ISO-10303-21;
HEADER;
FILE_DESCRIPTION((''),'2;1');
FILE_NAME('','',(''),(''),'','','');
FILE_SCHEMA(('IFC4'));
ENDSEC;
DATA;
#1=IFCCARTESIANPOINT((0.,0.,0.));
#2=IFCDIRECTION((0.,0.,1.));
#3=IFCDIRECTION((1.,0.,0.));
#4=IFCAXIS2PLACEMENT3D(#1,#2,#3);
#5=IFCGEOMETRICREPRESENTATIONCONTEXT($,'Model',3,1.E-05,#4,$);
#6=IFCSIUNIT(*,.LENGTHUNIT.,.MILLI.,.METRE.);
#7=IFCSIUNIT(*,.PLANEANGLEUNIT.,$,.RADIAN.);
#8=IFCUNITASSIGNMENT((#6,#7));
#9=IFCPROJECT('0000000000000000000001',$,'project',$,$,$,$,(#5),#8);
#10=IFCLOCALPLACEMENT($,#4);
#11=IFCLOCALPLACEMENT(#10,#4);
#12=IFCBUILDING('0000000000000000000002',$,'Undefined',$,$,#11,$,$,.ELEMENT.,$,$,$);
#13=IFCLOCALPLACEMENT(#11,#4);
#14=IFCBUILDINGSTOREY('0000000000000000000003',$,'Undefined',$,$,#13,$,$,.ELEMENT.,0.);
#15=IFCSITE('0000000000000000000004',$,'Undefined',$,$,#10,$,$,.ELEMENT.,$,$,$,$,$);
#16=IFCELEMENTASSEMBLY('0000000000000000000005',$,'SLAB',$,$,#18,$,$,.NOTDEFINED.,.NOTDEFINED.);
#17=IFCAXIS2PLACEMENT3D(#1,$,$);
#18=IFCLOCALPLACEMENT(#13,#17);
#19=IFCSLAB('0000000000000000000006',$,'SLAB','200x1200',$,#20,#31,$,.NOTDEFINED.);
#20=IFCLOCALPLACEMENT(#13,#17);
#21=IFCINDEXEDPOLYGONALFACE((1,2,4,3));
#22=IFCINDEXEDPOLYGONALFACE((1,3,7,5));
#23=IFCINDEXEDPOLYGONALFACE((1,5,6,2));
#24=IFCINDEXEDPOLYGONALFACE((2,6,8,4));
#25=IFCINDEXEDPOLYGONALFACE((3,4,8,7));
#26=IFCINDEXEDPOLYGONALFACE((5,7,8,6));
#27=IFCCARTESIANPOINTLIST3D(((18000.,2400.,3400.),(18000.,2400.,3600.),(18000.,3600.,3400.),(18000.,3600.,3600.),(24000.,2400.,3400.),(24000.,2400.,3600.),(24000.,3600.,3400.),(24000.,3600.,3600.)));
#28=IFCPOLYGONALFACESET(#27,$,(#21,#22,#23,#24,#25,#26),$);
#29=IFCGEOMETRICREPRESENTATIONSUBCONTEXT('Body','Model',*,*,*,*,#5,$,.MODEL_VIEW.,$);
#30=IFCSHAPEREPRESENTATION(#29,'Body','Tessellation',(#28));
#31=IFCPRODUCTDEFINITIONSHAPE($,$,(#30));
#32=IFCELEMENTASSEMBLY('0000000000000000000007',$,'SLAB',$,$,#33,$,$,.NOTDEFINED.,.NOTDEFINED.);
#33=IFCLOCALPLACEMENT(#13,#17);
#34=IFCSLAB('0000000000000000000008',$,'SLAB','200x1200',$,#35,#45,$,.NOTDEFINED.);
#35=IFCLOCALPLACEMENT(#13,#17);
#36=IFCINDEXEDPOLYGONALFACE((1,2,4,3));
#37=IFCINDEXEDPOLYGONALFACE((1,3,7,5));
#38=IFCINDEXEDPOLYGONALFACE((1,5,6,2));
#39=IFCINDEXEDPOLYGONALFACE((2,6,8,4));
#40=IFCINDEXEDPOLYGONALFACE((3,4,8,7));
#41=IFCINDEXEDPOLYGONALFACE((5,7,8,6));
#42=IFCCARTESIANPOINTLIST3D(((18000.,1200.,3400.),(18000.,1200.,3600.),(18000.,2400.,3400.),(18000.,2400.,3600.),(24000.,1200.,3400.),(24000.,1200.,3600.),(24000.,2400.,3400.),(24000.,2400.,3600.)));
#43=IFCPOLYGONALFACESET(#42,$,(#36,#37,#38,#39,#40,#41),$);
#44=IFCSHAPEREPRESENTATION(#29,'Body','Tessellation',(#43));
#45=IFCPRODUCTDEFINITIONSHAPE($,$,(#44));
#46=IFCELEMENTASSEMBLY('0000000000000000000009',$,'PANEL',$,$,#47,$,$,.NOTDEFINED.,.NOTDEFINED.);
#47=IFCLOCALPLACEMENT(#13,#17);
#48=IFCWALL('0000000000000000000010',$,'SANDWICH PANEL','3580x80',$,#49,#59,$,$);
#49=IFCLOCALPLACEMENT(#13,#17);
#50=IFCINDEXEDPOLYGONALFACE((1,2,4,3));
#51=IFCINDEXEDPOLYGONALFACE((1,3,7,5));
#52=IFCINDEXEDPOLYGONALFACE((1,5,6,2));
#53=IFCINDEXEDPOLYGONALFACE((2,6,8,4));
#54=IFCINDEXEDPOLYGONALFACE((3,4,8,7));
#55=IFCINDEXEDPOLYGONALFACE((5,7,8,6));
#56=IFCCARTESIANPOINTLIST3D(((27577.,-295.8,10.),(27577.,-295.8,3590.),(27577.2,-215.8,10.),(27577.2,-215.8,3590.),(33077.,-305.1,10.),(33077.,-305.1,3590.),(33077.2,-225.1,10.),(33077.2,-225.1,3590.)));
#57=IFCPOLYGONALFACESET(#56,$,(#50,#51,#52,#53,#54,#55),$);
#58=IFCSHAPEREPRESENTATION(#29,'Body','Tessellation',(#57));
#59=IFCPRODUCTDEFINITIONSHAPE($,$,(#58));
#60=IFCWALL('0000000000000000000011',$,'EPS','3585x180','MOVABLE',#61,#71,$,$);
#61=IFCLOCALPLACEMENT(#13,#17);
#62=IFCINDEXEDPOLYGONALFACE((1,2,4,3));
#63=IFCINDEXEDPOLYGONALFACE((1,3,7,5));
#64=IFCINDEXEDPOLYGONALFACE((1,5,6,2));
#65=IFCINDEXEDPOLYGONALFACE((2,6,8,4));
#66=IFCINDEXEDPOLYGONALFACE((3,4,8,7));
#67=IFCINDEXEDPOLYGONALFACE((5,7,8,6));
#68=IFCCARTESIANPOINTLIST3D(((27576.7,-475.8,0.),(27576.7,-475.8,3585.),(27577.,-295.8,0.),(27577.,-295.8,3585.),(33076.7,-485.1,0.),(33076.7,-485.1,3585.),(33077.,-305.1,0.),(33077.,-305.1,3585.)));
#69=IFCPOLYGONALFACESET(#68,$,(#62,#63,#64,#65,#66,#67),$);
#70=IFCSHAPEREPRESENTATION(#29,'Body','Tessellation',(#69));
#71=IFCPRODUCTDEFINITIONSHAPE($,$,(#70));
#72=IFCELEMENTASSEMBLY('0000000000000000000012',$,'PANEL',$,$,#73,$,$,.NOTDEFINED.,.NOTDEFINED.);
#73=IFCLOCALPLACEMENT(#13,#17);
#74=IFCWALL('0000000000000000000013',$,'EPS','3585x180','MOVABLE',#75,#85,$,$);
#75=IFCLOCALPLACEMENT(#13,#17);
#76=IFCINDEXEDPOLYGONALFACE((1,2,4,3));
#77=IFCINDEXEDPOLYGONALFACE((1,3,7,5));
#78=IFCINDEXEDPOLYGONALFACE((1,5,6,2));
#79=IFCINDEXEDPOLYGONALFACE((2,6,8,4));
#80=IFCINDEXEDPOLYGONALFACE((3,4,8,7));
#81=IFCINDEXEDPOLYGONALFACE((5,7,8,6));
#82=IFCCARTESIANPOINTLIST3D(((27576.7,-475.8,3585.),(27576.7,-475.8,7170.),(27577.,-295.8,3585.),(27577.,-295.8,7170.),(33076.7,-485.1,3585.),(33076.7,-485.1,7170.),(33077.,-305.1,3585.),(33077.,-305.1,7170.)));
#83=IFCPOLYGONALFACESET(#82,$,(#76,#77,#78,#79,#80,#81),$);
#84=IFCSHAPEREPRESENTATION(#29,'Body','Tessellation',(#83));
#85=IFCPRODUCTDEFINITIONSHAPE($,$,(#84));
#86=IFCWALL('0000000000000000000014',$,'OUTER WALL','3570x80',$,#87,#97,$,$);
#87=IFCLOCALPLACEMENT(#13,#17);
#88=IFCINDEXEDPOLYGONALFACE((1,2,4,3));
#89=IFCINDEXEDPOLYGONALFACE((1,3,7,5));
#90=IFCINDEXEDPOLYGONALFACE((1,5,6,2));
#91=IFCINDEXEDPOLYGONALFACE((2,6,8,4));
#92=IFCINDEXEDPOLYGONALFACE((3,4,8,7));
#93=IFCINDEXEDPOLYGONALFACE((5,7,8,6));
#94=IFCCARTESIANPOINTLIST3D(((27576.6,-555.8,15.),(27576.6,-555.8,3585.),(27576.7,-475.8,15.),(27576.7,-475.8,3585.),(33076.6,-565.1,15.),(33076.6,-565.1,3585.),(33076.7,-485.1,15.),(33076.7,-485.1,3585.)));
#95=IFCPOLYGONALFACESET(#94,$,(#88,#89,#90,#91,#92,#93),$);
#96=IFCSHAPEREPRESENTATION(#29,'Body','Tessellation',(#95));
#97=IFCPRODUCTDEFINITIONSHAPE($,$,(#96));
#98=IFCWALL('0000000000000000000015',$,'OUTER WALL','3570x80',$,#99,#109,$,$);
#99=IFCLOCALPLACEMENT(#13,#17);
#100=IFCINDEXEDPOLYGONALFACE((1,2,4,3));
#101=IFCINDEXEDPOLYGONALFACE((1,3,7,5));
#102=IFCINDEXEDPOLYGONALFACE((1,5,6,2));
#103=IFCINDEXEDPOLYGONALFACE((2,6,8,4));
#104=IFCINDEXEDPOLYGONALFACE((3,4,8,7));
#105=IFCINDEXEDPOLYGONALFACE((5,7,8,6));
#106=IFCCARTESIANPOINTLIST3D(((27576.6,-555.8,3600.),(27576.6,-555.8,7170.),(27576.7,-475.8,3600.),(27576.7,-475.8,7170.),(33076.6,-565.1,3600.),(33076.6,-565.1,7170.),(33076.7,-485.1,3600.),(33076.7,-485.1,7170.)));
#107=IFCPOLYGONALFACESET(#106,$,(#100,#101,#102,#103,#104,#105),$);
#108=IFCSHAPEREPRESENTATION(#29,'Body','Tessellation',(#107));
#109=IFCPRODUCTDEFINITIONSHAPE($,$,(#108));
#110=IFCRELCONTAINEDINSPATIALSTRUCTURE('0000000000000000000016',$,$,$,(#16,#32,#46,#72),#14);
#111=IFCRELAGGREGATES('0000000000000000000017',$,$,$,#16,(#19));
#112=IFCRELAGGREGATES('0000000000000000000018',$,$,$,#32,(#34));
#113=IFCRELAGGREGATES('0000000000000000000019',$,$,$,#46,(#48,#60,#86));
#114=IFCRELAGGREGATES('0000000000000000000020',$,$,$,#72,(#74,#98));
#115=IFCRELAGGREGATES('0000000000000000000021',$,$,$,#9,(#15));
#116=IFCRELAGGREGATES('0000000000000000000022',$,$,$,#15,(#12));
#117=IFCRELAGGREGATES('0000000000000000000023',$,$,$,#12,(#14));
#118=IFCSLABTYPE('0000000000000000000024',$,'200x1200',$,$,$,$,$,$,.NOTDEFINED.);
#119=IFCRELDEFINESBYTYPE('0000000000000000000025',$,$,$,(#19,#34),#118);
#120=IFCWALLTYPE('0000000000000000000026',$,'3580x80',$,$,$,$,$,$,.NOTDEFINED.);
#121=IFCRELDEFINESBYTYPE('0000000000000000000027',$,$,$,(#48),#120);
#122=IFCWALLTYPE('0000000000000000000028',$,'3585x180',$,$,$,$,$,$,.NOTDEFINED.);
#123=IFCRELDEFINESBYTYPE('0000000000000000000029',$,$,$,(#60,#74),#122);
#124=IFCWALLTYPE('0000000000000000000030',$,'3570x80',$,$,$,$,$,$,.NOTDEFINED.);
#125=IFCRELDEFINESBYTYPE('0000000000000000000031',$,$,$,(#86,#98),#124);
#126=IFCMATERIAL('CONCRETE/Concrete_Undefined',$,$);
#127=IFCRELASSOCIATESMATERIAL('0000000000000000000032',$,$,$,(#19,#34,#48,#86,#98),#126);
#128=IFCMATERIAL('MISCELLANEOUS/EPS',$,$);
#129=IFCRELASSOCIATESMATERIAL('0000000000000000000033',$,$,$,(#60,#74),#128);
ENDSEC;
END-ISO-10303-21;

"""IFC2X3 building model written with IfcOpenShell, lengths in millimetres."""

from ifc_helpers import new_model, si_unit, frame, frame_2d, origin_with_axes, place, context, subcontext, project, spatial, polyline, rectangle, outline, extrude, material, type_object, element, aggregate, save


model = new_model("IFC2X3")

# Units and contexts
model_context = context("Model", 3, precision=1e-05, world=origin_with_axes())
body_context = subcontext(model_context, "Body", "Model", "MODEL_VIEW")
ifc_project = project(units=[si_unit("LENGTHUNIT", "METRE", prefix="MILLI"), si_unit("PLANEANGLEUNIT", "RADIAN")], contexts=[model_context])

# Site, building, storey
site_placement = place(None, origin_with_axes())
site = spatial("IfcSite", under=ifc_project, at=site_placement, Name="Undefined", CompositionType="ELEMENT")
building_placement = place(site_placement, origin_with_axes())
building = spatial("IfcBuilding", under=site, at=building_placement, Name="Undefined", CompositionType="ELEMENT")
storey_placement = place(building_placement, origin_with_axes())
storey = spatial("IfcBuildingStorey", under=building, at=storey_placement, Name="Undefined", CompositionType="ELEMENT", Elevation=0.0)

# Shared definitions
ifc_material_1 = material(Name="CONCRETE/Concrete_Undefined")

# Element assemblies, slabs
slab_type = type_object("IfcSlabType", Name="200x1200", PredefinedType="NOTDEFINED")
assembly_1_placement = place(storey_placement, origin_with_axes())
assembly_1 = element("IfcElementAssembly", 1, at=assembly_1_placement, inside=storey, Name="SLAB", AssemblyPlace="NOTDEFINED", PredefinedType="NOTDEFINED")
slab_1_placement = place(assembly_1_placement, frame((24000.0, 2400.0, 3500.0), z_axis=(0.0, 0.0, 1.0), x_axis=(0.0, 1.0, 0.0)))
slab_1 = element("IfcSlab", 2, at=slab_1_placement, type_object=slab_type, material=ifc_material_1, Name="SLAB", Description="200x1200", PredefinedType="NOTDEFINED", context=body_context, shape_type="SweptSolid", body=[
    extrude(outline(polyline([(0.0, 0.0), (1200.0, 0.0), (1200.0, 6000.0), (0.0, 6000.0), (0.0, 0.0)])), frame((0.0, 0.0, -100.0), z_axis=(0.0, 0.0, 1.0), x_axis=(1.0, 0.0, 0.0)), (0.0, 0.0, 1.0), 200.0),
])
aggregate(assembly_1, [slab_1])
assembly_2_placement = place(storey_placement, origin_with_axes())
assembly_2 = element("IfcElementAssembly", 3, at=assembly_2_placement, inside=storey, Name="SLAB", AssemblyPlace="NOTDEFINED", PredefinedType="NOTDEFINED")
slab_2_placement = place(assembly_2_placement, frame((24000.0, 1200.0, 3500.0), z_axis=(0.0, 0.0, 1.0), x_axis=(0.0, 1.0, 0.0)))
slab_2 = element("IfcSlab", 4, at=slab_2_placement, type_object=slab_type, material=ifc_material_1, Name="SLAB", Description="200x1200", PredefinedType="NOTDEFINED", context=body_context, shape_type="SweptSolid", body=[
    extrude(outline(polyline([(0.0, 0.0), (1200.0, 0.0), (1200.0, 6000.0), (0.0, 6000.0), (0.0, 0.0)])), frame((0.0, 0.0, -100.0), z_axis=(0.0, 0.0, 1.0), x_axis=(1.0, 0.0, 0.0)), (0.0, 0.0, 1.0), 200.0),
])
aggregate(assembly_2, [slab_2])

# Element assembly, walls
assembly_3_placement = place(storey_placement, origin_with_axes())
assembly_3 = element("IfcElementAssembly", 5, at=assembly_3_placement, inside=storey, Name="PANEL", AssemblyPlace="NOTDEFINED", PredefinedType="NOTDEFINED")
wall_type_1 = type_object("IfcWallType", Name="3580x80", PredefinedType="NOTDEFINED")
wall_1_placement = place(assembly_3_placement, frame((27577.1, -255.8, 10.0), z_axis=(0.0, 0.0, 1.0), x_axis=(0.999999, -0.001684, 0.0)))
wall_1 = element("IfcWall", 6, at=wall_1_placement, type_object=wall_type_1, material=ifc_material_1, Name="SANDWICH PANEL", Description="3580x80", context=body_context, shape_type="SweptSolid", body=[
    extrude(rectangle(XDim=5500.0, YDim=80.0, at=frame_2d((0.0, 2750.0), x_axis=(0.0, -1.0))), frame((0.0, 0.0, 0.0), z_axis=(0.0, 0.0, 1.0), x_axis=(0.0, -1.0, 0.0)), (0.0, 0.0, 1.0), 3580.0),
])
ifc_material_2 = material(Name="MISCELLANEOUS/EPS")
wall_type_2 = type_object("IfcWallType", Name="3585x180", PredefinedType="NOTDEFINED")
wall_2_placement = place(assembly_3_placement, frame((27576.9, -385.8, 0.0), z_axis=(0.0, 0.0, 1.0), x_axis=(0.999999, -0.001684, 0.0)))
wall_2 = element("IfcWall", 7, at=wall_2_placement, type_object=wall_type_2, material=ifc_material_2, Name="EPS", Description="3585x180", ObjectType="MOVABLE", context=body_context, shape_type="SweptSolid", body=[
    extrude(rectangle(XDim=5500.0, YDim=180.0, at=frame_2d((0.0, 2750.0), x_axis=(0.0, -1.0))), frame((0.0, 0.0, 0.0), z_axis=(0.0, 0.0, 1.0), x_axis=(0.0, -1.0, 0.0)), (0.0, 0.0, 1.0), 3585.0),
])

# Element assembly, wall
assembly_4_placement = place(storey_placement, origin_with_axes())
assembly_4 = element("IfcElementAssembly", 8, at=assembly_4_placement, inside=storey, Name="PANEL", AssemblyPlace="NOTDEFINED", PredefinedType="NOTDEFINED")
wall_3_placement = place(assembly_4_placement, frame((27576.9, -385.8, 3585.0), z_axis=(0.0, 0.0, 1.0), x_axis=(0.999999, -0.001684, 0.0)))
wall_3 = element("IfcWall", 9, at=wall_3_placement, type_object=wall_type_2, material=ifc_material_2, Name="EPS", Description="3585x180", ObjectType="MOVABLE", context=body_context, shape_type="SweptSolid", body=[
    extrude(rectangle(XDim=5500.0, YDim=180.0, at=frame_2d((0.0, 2750.0), x_axis=(0.0, -1.0))), frame((0.0, 0.0, 0.0), z_axis=(0.0, 0.0, 1.0), x_axis=(0.0, -1.0, 0.0)), (0.0, 0.0, 1.0), 3585.0),
])

# Walls
wall_type_3 = type_object("IfcWallType", Name="3570x80", PredefinedType="NOTDEFINED")
wall_4_placement = place(assembly_3_placement, frame((27576.7, -515.8, 15.0), z_axis=(0.0, 0.0, 1.0), x_axis=(0.999999, -0.001684, 0.0)))
wall_4 = element("IfcWall", 10, at=wall_4_placement, type_object=wall_type_3, material=ifc_material_1, Name="OUTER WALL", Description="3570x80", context=body_context, shape_type="SweptSolid", body=[
    extrude(rectangle(XDim=5500.0, YDim=80.0, at=frame_2d((0.0, 2750.0), x_axis=(0.0, -1.0))), frame((0.0, 0.0, 0.0), z_axis=(0.0, 0.0, 1.0), x_axis=(0.0, -1.0, 0.0)), (0.0, 0.0, 1.0), 3570.0),
])
aggregate(assembly_3, [wall_1, wall_2, wall_4])
wall_5_placement = place(assembly_4_placement, frame((27576.7, -515.8, 3600.0), z_axis=(0.0, 0.0, 1.0), x_axis=(0.999999, -0.001684, 0.0)))
wall_5 = element("IfcWall", 11, at=wall_5_placement, type_object=wall_type_3, material=ifc_material_1, Name="OUTER WALL", Description="3570x80", context=body_context, shape_type="SweptSolid", body=[
    extrude(rectangle(XDim=5500.0, YDim=80.0, at=frame_2d((0.0, 2750.0), x_axis=(0.0, -1.0))), frame((0.0, 0.0, 0.0), z_axis=(0.0, 0.0, 1.0), x_axis=(0.0, -1.0, 0.0)), (0.0, 0.0, 1.0), 3570.0),
])
aggregate(assembly_4, [wall_3, wall_5])

save(model, "model.ifc")
